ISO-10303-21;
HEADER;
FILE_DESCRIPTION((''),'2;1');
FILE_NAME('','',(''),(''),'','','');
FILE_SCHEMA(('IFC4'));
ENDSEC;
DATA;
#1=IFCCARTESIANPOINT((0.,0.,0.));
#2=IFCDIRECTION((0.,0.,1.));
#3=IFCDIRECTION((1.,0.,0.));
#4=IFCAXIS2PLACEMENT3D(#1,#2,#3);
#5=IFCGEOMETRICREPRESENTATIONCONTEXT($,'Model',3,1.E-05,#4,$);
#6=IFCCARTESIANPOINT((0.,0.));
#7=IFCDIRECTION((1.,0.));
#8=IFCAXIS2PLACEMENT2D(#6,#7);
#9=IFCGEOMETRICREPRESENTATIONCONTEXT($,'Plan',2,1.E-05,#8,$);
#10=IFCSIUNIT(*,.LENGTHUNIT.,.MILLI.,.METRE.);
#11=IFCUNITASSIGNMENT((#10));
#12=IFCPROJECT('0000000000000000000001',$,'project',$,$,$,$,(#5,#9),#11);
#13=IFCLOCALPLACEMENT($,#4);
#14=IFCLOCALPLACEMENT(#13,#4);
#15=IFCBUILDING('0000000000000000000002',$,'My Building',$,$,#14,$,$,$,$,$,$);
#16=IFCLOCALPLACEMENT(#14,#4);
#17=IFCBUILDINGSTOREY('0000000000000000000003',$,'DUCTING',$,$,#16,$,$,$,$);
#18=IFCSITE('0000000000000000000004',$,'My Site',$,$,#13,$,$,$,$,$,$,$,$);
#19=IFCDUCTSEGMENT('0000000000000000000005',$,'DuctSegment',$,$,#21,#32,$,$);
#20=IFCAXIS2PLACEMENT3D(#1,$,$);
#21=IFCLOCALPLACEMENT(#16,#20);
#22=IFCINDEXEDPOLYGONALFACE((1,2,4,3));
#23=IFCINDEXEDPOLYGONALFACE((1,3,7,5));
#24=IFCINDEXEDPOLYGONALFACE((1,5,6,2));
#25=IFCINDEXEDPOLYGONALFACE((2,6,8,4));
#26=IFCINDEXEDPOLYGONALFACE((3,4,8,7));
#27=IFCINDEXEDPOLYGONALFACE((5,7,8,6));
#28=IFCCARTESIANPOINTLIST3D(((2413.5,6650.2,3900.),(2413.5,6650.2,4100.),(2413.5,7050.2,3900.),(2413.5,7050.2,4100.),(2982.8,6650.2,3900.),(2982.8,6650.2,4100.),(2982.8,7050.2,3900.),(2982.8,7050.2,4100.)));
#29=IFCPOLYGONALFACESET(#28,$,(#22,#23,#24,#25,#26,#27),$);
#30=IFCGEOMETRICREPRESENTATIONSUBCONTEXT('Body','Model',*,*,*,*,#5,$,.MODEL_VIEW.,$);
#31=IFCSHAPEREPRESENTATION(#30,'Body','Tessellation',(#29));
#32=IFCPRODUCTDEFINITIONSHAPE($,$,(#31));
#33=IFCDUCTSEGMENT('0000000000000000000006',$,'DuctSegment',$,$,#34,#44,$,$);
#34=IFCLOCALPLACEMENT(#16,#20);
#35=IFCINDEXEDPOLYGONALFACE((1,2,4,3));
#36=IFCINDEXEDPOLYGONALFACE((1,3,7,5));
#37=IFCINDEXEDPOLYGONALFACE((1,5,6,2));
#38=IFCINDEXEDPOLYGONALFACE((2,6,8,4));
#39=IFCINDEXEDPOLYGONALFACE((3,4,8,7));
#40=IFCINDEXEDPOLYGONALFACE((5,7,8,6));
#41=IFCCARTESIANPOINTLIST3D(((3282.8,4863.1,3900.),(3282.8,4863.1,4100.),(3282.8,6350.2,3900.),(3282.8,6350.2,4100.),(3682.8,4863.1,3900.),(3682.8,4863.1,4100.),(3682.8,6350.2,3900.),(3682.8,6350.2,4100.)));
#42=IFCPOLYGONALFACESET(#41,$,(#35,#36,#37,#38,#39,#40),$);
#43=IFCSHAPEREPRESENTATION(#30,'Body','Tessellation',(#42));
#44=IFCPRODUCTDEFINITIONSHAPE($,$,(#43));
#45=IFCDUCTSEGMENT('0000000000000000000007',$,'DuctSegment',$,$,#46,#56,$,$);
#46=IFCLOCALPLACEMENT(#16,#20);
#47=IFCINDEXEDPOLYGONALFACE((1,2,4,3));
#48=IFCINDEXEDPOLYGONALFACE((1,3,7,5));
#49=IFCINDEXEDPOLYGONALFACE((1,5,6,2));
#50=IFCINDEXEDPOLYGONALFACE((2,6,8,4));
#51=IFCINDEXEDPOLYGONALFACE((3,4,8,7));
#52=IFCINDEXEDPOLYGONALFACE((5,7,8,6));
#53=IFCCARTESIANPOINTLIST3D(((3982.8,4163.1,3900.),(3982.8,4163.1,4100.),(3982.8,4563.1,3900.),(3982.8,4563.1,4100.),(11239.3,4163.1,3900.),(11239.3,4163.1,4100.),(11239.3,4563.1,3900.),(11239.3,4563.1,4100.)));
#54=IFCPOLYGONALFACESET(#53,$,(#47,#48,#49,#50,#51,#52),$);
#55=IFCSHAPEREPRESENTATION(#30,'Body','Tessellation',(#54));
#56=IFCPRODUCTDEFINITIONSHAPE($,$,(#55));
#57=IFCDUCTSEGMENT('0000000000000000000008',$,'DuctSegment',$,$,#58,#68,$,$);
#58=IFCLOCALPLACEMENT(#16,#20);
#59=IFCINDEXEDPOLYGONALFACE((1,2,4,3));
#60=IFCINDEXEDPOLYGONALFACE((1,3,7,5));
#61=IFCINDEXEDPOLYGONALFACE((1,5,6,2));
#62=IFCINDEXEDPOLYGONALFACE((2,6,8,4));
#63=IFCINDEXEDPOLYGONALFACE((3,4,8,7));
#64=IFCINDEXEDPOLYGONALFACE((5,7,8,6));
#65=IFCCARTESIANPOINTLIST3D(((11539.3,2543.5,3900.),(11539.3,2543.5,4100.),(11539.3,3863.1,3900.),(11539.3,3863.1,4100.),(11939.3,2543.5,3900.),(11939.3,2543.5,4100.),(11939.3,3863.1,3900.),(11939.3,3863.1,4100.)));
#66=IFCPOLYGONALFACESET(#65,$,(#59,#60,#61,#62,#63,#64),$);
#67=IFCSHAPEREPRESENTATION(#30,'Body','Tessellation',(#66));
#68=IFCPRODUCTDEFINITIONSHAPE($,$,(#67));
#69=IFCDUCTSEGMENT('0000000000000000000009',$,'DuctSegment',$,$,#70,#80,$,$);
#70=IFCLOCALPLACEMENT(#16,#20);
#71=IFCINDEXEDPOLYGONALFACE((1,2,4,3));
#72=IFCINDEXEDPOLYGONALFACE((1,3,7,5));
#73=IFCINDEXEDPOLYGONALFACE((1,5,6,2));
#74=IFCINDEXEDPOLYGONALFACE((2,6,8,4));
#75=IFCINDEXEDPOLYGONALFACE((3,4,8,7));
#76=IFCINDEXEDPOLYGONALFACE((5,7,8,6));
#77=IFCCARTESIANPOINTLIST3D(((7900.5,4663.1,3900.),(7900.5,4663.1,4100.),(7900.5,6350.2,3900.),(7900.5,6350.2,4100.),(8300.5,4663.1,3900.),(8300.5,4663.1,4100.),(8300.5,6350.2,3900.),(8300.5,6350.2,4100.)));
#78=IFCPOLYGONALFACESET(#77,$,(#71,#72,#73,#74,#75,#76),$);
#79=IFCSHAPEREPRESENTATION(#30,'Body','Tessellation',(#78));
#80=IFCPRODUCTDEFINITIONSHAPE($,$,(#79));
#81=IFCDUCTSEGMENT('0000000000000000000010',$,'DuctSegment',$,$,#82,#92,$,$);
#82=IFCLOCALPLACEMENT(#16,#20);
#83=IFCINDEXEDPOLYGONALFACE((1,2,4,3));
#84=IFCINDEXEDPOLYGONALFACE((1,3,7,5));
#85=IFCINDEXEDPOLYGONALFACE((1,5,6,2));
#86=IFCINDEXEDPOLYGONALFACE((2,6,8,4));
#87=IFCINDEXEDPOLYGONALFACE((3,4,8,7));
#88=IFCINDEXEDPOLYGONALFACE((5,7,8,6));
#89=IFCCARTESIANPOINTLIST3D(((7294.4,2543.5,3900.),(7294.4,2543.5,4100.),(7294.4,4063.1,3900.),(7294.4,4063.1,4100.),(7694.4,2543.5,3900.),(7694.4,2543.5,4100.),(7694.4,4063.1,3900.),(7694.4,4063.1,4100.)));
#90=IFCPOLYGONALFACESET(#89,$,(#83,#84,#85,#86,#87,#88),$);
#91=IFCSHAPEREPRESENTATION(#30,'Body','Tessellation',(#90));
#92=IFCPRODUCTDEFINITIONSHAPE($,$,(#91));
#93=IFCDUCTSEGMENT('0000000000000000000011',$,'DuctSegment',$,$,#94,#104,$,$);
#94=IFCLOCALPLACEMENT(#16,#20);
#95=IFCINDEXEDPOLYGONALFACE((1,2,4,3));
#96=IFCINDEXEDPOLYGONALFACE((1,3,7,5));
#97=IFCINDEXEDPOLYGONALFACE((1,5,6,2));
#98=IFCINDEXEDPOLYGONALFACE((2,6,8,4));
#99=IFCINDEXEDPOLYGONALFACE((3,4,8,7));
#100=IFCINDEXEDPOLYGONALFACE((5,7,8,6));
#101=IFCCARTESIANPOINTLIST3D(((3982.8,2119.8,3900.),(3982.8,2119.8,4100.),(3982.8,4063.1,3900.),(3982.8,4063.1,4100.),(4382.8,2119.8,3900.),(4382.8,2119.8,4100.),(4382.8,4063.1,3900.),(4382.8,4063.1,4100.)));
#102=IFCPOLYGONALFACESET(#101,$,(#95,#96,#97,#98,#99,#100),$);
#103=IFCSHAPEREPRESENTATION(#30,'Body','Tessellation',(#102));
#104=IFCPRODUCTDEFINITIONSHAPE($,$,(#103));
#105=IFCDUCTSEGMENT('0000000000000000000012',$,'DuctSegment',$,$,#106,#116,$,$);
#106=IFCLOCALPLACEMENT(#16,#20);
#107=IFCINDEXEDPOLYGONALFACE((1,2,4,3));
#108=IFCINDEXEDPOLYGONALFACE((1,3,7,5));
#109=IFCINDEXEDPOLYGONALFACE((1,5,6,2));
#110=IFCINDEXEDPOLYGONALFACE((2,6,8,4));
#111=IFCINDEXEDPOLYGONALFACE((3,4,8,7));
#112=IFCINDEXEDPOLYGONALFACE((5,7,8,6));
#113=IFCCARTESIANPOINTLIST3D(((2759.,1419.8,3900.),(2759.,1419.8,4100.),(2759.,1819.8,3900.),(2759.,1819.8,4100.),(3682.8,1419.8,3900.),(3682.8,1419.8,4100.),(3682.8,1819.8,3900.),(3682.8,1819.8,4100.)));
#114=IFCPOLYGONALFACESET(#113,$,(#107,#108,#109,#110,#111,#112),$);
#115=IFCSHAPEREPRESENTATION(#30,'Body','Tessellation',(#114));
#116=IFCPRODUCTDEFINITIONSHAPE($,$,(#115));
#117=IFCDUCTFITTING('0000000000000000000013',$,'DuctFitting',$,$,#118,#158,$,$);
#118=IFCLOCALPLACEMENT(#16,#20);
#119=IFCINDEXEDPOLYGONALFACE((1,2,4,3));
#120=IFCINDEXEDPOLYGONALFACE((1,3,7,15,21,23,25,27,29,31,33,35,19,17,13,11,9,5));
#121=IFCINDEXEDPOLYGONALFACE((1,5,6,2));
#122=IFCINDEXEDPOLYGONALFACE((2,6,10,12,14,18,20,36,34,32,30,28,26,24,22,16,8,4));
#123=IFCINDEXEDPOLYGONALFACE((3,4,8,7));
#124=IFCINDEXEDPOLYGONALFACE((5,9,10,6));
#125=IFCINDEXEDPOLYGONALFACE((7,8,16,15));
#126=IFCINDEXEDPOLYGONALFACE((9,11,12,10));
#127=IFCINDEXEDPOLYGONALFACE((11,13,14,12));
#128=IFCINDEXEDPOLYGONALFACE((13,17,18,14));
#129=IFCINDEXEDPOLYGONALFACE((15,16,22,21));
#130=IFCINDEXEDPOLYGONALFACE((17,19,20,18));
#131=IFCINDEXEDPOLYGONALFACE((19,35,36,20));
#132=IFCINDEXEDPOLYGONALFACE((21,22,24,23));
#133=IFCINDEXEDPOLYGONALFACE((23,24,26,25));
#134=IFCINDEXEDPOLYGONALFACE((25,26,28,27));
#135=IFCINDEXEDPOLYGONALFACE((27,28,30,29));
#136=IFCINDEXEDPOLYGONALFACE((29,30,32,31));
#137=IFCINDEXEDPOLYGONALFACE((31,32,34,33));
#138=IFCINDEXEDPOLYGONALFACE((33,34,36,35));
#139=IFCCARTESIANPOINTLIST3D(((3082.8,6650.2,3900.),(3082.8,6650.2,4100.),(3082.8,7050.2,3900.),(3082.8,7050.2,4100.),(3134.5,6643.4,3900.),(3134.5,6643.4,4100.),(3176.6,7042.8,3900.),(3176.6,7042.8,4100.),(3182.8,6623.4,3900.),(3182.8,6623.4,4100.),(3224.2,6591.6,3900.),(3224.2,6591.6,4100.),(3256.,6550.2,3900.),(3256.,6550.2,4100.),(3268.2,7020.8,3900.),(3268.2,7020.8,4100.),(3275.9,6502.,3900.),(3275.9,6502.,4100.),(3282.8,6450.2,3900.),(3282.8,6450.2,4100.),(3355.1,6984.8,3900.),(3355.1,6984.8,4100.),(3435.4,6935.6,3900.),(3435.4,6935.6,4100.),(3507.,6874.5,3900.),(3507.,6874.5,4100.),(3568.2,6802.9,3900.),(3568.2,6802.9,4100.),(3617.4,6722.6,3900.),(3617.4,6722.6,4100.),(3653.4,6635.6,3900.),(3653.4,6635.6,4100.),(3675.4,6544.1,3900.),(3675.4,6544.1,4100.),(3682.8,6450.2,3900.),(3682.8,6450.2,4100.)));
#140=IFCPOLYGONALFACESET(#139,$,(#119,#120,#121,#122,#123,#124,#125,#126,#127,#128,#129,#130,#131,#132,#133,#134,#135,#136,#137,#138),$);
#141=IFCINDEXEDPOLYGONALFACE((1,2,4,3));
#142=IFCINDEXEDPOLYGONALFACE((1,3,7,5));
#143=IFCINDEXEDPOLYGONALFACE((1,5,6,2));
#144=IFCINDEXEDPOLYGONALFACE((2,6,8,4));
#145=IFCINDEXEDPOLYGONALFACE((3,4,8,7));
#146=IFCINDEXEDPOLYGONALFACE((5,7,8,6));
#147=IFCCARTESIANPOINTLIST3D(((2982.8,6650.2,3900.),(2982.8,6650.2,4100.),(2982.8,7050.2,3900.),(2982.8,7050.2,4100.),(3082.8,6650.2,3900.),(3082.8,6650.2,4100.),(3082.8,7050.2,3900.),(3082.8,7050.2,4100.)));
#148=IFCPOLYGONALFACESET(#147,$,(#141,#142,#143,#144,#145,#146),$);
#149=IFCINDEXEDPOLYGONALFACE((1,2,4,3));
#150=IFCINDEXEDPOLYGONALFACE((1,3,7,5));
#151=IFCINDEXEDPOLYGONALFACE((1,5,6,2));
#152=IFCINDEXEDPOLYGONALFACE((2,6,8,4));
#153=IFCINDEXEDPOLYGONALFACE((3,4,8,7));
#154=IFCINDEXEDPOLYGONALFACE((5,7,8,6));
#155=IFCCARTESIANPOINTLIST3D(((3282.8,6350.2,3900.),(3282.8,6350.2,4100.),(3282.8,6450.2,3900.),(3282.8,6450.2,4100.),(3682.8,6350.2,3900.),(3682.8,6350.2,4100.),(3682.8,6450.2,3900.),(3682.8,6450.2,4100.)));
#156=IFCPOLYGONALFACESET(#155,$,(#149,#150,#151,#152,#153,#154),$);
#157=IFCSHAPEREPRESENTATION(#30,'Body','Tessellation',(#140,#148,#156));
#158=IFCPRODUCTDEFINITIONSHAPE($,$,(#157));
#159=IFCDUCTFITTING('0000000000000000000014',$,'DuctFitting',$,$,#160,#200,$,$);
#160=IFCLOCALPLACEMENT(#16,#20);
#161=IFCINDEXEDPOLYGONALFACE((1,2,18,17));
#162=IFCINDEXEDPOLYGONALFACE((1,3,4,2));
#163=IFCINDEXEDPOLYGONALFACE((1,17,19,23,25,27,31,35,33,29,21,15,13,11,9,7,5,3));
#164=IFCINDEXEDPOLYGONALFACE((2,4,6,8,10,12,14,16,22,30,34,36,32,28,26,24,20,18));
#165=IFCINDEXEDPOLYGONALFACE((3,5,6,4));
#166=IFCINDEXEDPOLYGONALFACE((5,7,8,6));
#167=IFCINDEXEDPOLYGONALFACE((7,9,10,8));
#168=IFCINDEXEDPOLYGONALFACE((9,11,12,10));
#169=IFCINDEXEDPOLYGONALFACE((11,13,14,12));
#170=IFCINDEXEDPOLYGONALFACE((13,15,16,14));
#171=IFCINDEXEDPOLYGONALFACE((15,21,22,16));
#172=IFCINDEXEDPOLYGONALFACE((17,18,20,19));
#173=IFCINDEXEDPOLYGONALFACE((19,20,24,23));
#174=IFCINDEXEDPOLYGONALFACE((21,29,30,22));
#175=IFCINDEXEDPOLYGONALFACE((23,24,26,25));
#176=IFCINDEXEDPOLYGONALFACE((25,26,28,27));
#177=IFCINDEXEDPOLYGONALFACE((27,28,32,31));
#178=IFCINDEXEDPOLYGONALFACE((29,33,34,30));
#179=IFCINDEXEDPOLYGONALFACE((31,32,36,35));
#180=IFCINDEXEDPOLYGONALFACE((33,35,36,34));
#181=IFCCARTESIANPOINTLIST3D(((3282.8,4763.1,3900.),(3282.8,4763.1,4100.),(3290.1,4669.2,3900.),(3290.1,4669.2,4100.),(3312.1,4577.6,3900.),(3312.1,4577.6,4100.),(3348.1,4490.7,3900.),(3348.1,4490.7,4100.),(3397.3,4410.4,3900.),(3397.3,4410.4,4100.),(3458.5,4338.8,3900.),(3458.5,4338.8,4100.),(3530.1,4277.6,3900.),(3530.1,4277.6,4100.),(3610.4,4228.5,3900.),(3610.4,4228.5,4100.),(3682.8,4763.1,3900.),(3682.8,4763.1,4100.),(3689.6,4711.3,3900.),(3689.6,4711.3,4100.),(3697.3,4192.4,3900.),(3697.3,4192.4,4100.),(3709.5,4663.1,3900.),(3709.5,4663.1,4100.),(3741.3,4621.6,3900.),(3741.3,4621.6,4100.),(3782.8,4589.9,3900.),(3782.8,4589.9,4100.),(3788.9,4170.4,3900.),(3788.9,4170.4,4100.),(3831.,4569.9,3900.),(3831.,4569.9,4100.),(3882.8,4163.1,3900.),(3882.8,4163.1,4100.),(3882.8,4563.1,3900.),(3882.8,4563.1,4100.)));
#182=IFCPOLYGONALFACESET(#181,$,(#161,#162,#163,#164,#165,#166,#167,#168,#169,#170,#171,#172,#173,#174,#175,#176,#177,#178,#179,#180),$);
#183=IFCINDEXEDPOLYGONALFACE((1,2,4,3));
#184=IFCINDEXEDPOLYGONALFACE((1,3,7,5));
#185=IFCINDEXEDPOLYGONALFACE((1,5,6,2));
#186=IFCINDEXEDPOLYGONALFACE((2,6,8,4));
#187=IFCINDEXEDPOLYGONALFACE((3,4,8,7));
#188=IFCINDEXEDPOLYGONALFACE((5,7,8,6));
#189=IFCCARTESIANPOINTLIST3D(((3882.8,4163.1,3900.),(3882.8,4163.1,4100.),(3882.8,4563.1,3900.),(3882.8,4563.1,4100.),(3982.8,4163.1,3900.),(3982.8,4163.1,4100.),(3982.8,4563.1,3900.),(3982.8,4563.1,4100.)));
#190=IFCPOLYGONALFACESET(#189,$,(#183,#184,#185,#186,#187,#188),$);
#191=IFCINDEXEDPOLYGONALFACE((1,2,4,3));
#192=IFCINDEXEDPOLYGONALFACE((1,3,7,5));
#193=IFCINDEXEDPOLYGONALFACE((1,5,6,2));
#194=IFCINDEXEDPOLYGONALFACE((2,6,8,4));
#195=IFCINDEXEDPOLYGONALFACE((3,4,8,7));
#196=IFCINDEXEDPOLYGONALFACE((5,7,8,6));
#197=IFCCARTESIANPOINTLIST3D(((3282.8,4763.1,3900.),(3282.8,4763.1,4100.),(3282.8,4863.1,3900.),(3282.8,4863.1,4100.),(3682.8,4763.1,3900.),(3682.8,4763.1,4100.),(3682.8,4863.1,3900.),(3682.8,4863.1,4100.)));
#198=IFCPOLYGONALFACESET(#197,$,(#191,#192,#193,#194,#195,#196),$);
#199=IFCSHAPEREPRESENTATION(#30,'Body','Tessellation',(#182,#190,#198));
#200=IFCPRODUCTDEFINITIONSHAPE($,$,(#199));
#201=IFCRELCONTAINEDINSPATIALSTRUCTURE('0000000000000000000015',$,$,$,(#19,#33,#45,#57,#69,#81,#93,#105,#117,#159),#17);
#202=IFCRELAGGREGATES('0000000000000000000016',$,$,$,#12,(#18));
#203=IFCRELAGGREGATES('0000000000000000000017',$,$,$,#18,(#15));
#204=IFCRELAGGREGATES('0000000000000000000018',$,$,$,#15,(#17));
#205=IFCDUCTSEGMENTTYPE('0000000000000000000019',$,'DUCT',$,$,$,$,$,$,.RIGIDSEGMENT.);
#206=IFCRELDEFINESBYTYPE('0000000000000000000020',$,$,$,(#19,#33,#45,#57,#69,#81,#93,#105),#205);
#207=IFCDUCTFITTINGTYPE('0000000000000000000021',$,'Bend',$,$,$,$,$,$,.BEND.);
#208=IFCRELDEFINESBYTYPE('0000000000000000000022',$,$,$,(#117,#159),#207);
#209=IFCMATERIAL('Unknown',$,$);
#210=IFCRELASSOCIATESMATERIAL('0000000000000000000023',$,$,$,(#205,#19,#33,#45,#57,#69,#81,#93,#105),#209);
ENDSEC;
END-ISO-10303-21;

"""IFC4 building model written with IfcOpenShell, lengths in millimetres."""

from ifc_helpers import new_model, si_unit, frame, origin_with_axes, origin_2d_with_axis, place, context, subcontext, project, spatial, line, arc, indexed_curve, rectangle, outline, extrude, source, transform, mapped, material, material_profile, profile_set, profile_usage, type_object, type_shapes, element, save


model = new_model("IFC4")

# Units and contexts
model_context = context("Model", 3, precision=1e-05, world=origin_with_axes())
plan_context = context("Plan", 2, precision=1e-05, world=origin_2d_with_axis())
body_context = subcontext(model_context, "Body", "Model", "MODEL_VIEW")
ifc_project = project(units=[si_unit("LENGTHUNIT", "METRE", prefix="MILLI")], contexts=[model_context, plan_context])

# Site, building, storey
site_placement = place(None, origin_with_axes())
site = spatial("IfcSite", under=ifc_project, at=site_placement, Name="My Site")
building_placement = place(site_placement, origin_with_axes())
building = spatial("IfcBuilding", under=site, at=building_placement, Name="My Building")
storey_placement = place(building_placement, origin_with_axes())
storey = spatial("IfcBuildingStorey", under=building, at=storey_placement, Name="DUCTING")

# Duct segments
ifc_material = material(Name="Unknown")
ifc_material_profile_1 = material_profile(ifc_material, rectangle(XDim=400.0, YDim=200.0))
ifc_profile_set_1 = profile_set([ifc_material_profile_1])
ifc_profile_usage_1 = profile_usage(ifc_profile_set_1, cardinal=5)
duct_segment_type = type_object("IfcDuctSegmentType", Name="DUCT", PredefinedType="RIGIDSEGMENT", material=ifc_profile_set_1)
duct_segment_1_placement = place(storey_placement, frame((2413.5, 6850.2, 4000.0), z_axis=(1.0, 0.0, 0.0), x_axis=(0.0, 1.0, 0.0)))
element("IfcDuctSegment", 1, at=duct_segment_1_placement, inside=storey, type_object=duct_segment_type, material=ifc_profile_usage_1, Name="DuctSegment", context=body_context, shape_type="SweptSolid", body=[
    extrude(rectangle(XDim=400.0, YDim=200.0), origin_with_axes(), (0.0, 0.0, 1.0), 569.3),
])
ifc_profile_usage_2 = profile_usage(ifc_profile_set_1, cardinal=5)
duct_segment_2_placement = place(storey_placement, frame((3482.8, 6350.2, 4000.0), z_axis=(0.0, -1.0, 0.0), x_axis=(1.0, 0.0, 0.0)))
element("IfcDuctSegment", 2, at=duct_segment_2_placement, inside=storey, type_object=duct_segment_type, material=ifc_profile_usage_2, Name="DuctSegment", context=body_context, shape_type="SweptSolid", body=[
    extrude(rectangle(XDim=400.0, YDim=200.0), origin_with_axes(), (0.0, 0.0, 1.0), 1487.1),
])
ifc_profile_usage_3 = profile_usage(ifc_profile_set_1, cardinal=5)
duct_segment_3_placement = place(storey_placement, frame((3982.8, 4363.1, 4000.0), z_axis=(1.0, 0.0, 0.0), x_axis=(0.0, 1.0, 0.0)))
element("IfcDuctSegment", 3, at=duct_segment_3_placement, inside=storey, type_object=duct_segment_type, material=ifc_profile_usage_3, Name="DuctSegment", context=body_context, shape_type="SweptSolid", body=[
    extrude(rectangle(XDim=400.0, YDim=200.0), origin_with_axes(), (0.0, 0.0, 1.0), 7256.5),
])
ifc_profile_usage_4 = profile_usage(ifc_profile_set_1, cardinal=5)
duct_segment_4_placement = place(storey_placement, frame((11739.3, 3863.1, 4000.0), z_axis=(0.0, -1.0, 0.0), x_axis=(1.0, 0.0, 0.0)))
element("IfcDuctSegment", 4, at=duct_segment_4_placement, inside=storey, type_object=duct_segment_type, material=ifc_profile_usage_4, Name="DuctSegment", context=body_context, shape_type="SweptSolid", body=[
    extrude(rectangle(XDim=400.0, YDim=200.0), origin_with_axes(), (0.0, 0.0, 1.0), 1319.5),
])
ifc_profile_usage_5 = profile_usage(ifc_profile_set_1, cardinal=5)
duct_segment_5_placement = place(storey_placement, frame((8100.5, 6350.2, 4000.0), z_axis=(0.0, -1.0, 0.0), x_axis=(1.0, 0.0, 0.0)))
element("IfcDuctSegment", 5, at=duct_segment_5_placement, inside=storey, type_object=duct_segment_type, material=ifc_profile_usage_5, Name="DuctSegment", context=body_context, shape_type="SweptSolid", body=[
    extrude(rectangle(XDim=400.0, YDim=200.0), origin_with_axes(), (0.0, 0.0, 1.0), 1687.1),
])
ifc_profile_usage_6 = profile_usage(ifc_profile_set_1, cardinal=5)
duct_segment_6_placement = place(storey_placement, frame((7494.4, 4063.1, 4000.0), z_axis=(0.0, -1.0, 0.0), x_axis=(1.0, 0.0, 0.0)))
element("IfcDuctSegment", 6, at=duct_segment_6_placement, inside=storey, type_object=duct_segment_type, material=ifc_profile_usage_6, Name="DuctSegment", context=body_context, shape_type="SweptSolid", body=[
    extrude(rectangle(XDim=400.0, YDim=200.0), origin_with_axes(), (0.0, 0.0, 1.0), 1519.5),
])
ifc_profile_usage_7 = profile_usage(ifc_profile_set_1, cardinal=5)
duct_segment_7_placement = place(storey_placement, frame((4182.8, 4063.1, 4000.0), z_axis=(0.0, -1.0, 0.0), x_axis=(1.0, 0.0, 0.0)))
element("IfcDuctSegment", 7, at=duct_segment_7_placement, inside=storey, type_object=duct_segment_type, material=ifc_profile_usage_7, Name="DuctSegment", context=body_context, shape_type="SweptSolid", body=[
    extrude(rectangle(XDim=400.0, YDim=200.0), origin_with_axes(), (0.0, 0.0, 1.0), 1943.3),
])
ifc_profile_usage_8 = profile_usage(ifc_profile_set_1, cardinal=5)
duct_segment_8_placement = place(storey_placement, frame((2759.0, 1619.8, 4000.0), z_axis=(1.0, 0.0, 0.0), x_axis=(0.0, 1.0, 0.0)))
element("IfcDuctSegment", 8, at=duct_segment_8_placement, inside=storey, type_object=duct_segment_type, material=ifc_profile_usage_8, Name="DuctSegment", context=body_context, shape_type="SweptSolid", body=[
    extrude(rectangle(XDim=400.0, YDim=200.0), origin_with_axes(), (0.0, 0.0, 1.0), 923.7),
])

# Duct fittings
duct_fitting_type_1 = type_object("IfcDuctFittingType", Name="Bend", PredefinedType="BEND")
shared_shape = source(origin_with_axes(), body_context, "Body", "SweptSolid", [
    extrude(outline(indexed_curve([(-200.0, 0.0), (-258.6, 141.4), (-400.0, 200.0), (-400.0, 600.0), (24.3, 424.3), (200.0, 0.0)], segments=[arc(1, 2, 3), line(3, 4), arc(4, 5, 6), line(6, 1)])), frame((0.0, -100.0, 100.0), z_axis=(0.0, -1.0, 0.0), x_axis=(1.0, 0.0, 0.0)), (0.0, 0.0, -1.0), 200.0),
    extrude(rectangle(XDim=400.0, YDim=200.0), origin_with_axes(), (0.0, 0.0, 1.0), 100.0),
    extrude(rectangle(XDim=400.0, YDim=200.0), frame((-400.0, 0.0, 500.0), z_axis=(-1.0, 0.0, 0.0), x_axis=(0.0, 0.0, -1.0)), (0.0, 0.0, 1.0), 100.0),
])
type_shapes(duct_fitting_type_1, [shared_shape])
for number, where, z_axis, x_axis, name in (
    (9, (2982.8, 6850.2, 4000.0), (1.0, 0.0, 0.0), (0.0, 1.0, 0.0), "DuctFitting"),
    (10, (3982.8, 4363.1, 4000.0), (-1.0, 0.0, 0.0), (0.0, -1.0, 0.0), "DuctFitting"),
):
    element("IfcDuctFitting", number, at=place(storey_placement, frame(where, z_axis=z_axis, x_axis=x_axis)), inside=storey, type_object=duct_fitting_type_1, Name=name, context=body_context, shape_type="MappedRepresentation", body=[
        mapped(shared_shape, transform((0.0, 0.0, 0.0), x_axis=(1.0, 0.0, 0.0), y_axis=(0.0, 1.0, 0.0), z_axis=(0.0, 0.0, 1.0), scale=1.0)),
    ])

save(model, "model.ifc")
